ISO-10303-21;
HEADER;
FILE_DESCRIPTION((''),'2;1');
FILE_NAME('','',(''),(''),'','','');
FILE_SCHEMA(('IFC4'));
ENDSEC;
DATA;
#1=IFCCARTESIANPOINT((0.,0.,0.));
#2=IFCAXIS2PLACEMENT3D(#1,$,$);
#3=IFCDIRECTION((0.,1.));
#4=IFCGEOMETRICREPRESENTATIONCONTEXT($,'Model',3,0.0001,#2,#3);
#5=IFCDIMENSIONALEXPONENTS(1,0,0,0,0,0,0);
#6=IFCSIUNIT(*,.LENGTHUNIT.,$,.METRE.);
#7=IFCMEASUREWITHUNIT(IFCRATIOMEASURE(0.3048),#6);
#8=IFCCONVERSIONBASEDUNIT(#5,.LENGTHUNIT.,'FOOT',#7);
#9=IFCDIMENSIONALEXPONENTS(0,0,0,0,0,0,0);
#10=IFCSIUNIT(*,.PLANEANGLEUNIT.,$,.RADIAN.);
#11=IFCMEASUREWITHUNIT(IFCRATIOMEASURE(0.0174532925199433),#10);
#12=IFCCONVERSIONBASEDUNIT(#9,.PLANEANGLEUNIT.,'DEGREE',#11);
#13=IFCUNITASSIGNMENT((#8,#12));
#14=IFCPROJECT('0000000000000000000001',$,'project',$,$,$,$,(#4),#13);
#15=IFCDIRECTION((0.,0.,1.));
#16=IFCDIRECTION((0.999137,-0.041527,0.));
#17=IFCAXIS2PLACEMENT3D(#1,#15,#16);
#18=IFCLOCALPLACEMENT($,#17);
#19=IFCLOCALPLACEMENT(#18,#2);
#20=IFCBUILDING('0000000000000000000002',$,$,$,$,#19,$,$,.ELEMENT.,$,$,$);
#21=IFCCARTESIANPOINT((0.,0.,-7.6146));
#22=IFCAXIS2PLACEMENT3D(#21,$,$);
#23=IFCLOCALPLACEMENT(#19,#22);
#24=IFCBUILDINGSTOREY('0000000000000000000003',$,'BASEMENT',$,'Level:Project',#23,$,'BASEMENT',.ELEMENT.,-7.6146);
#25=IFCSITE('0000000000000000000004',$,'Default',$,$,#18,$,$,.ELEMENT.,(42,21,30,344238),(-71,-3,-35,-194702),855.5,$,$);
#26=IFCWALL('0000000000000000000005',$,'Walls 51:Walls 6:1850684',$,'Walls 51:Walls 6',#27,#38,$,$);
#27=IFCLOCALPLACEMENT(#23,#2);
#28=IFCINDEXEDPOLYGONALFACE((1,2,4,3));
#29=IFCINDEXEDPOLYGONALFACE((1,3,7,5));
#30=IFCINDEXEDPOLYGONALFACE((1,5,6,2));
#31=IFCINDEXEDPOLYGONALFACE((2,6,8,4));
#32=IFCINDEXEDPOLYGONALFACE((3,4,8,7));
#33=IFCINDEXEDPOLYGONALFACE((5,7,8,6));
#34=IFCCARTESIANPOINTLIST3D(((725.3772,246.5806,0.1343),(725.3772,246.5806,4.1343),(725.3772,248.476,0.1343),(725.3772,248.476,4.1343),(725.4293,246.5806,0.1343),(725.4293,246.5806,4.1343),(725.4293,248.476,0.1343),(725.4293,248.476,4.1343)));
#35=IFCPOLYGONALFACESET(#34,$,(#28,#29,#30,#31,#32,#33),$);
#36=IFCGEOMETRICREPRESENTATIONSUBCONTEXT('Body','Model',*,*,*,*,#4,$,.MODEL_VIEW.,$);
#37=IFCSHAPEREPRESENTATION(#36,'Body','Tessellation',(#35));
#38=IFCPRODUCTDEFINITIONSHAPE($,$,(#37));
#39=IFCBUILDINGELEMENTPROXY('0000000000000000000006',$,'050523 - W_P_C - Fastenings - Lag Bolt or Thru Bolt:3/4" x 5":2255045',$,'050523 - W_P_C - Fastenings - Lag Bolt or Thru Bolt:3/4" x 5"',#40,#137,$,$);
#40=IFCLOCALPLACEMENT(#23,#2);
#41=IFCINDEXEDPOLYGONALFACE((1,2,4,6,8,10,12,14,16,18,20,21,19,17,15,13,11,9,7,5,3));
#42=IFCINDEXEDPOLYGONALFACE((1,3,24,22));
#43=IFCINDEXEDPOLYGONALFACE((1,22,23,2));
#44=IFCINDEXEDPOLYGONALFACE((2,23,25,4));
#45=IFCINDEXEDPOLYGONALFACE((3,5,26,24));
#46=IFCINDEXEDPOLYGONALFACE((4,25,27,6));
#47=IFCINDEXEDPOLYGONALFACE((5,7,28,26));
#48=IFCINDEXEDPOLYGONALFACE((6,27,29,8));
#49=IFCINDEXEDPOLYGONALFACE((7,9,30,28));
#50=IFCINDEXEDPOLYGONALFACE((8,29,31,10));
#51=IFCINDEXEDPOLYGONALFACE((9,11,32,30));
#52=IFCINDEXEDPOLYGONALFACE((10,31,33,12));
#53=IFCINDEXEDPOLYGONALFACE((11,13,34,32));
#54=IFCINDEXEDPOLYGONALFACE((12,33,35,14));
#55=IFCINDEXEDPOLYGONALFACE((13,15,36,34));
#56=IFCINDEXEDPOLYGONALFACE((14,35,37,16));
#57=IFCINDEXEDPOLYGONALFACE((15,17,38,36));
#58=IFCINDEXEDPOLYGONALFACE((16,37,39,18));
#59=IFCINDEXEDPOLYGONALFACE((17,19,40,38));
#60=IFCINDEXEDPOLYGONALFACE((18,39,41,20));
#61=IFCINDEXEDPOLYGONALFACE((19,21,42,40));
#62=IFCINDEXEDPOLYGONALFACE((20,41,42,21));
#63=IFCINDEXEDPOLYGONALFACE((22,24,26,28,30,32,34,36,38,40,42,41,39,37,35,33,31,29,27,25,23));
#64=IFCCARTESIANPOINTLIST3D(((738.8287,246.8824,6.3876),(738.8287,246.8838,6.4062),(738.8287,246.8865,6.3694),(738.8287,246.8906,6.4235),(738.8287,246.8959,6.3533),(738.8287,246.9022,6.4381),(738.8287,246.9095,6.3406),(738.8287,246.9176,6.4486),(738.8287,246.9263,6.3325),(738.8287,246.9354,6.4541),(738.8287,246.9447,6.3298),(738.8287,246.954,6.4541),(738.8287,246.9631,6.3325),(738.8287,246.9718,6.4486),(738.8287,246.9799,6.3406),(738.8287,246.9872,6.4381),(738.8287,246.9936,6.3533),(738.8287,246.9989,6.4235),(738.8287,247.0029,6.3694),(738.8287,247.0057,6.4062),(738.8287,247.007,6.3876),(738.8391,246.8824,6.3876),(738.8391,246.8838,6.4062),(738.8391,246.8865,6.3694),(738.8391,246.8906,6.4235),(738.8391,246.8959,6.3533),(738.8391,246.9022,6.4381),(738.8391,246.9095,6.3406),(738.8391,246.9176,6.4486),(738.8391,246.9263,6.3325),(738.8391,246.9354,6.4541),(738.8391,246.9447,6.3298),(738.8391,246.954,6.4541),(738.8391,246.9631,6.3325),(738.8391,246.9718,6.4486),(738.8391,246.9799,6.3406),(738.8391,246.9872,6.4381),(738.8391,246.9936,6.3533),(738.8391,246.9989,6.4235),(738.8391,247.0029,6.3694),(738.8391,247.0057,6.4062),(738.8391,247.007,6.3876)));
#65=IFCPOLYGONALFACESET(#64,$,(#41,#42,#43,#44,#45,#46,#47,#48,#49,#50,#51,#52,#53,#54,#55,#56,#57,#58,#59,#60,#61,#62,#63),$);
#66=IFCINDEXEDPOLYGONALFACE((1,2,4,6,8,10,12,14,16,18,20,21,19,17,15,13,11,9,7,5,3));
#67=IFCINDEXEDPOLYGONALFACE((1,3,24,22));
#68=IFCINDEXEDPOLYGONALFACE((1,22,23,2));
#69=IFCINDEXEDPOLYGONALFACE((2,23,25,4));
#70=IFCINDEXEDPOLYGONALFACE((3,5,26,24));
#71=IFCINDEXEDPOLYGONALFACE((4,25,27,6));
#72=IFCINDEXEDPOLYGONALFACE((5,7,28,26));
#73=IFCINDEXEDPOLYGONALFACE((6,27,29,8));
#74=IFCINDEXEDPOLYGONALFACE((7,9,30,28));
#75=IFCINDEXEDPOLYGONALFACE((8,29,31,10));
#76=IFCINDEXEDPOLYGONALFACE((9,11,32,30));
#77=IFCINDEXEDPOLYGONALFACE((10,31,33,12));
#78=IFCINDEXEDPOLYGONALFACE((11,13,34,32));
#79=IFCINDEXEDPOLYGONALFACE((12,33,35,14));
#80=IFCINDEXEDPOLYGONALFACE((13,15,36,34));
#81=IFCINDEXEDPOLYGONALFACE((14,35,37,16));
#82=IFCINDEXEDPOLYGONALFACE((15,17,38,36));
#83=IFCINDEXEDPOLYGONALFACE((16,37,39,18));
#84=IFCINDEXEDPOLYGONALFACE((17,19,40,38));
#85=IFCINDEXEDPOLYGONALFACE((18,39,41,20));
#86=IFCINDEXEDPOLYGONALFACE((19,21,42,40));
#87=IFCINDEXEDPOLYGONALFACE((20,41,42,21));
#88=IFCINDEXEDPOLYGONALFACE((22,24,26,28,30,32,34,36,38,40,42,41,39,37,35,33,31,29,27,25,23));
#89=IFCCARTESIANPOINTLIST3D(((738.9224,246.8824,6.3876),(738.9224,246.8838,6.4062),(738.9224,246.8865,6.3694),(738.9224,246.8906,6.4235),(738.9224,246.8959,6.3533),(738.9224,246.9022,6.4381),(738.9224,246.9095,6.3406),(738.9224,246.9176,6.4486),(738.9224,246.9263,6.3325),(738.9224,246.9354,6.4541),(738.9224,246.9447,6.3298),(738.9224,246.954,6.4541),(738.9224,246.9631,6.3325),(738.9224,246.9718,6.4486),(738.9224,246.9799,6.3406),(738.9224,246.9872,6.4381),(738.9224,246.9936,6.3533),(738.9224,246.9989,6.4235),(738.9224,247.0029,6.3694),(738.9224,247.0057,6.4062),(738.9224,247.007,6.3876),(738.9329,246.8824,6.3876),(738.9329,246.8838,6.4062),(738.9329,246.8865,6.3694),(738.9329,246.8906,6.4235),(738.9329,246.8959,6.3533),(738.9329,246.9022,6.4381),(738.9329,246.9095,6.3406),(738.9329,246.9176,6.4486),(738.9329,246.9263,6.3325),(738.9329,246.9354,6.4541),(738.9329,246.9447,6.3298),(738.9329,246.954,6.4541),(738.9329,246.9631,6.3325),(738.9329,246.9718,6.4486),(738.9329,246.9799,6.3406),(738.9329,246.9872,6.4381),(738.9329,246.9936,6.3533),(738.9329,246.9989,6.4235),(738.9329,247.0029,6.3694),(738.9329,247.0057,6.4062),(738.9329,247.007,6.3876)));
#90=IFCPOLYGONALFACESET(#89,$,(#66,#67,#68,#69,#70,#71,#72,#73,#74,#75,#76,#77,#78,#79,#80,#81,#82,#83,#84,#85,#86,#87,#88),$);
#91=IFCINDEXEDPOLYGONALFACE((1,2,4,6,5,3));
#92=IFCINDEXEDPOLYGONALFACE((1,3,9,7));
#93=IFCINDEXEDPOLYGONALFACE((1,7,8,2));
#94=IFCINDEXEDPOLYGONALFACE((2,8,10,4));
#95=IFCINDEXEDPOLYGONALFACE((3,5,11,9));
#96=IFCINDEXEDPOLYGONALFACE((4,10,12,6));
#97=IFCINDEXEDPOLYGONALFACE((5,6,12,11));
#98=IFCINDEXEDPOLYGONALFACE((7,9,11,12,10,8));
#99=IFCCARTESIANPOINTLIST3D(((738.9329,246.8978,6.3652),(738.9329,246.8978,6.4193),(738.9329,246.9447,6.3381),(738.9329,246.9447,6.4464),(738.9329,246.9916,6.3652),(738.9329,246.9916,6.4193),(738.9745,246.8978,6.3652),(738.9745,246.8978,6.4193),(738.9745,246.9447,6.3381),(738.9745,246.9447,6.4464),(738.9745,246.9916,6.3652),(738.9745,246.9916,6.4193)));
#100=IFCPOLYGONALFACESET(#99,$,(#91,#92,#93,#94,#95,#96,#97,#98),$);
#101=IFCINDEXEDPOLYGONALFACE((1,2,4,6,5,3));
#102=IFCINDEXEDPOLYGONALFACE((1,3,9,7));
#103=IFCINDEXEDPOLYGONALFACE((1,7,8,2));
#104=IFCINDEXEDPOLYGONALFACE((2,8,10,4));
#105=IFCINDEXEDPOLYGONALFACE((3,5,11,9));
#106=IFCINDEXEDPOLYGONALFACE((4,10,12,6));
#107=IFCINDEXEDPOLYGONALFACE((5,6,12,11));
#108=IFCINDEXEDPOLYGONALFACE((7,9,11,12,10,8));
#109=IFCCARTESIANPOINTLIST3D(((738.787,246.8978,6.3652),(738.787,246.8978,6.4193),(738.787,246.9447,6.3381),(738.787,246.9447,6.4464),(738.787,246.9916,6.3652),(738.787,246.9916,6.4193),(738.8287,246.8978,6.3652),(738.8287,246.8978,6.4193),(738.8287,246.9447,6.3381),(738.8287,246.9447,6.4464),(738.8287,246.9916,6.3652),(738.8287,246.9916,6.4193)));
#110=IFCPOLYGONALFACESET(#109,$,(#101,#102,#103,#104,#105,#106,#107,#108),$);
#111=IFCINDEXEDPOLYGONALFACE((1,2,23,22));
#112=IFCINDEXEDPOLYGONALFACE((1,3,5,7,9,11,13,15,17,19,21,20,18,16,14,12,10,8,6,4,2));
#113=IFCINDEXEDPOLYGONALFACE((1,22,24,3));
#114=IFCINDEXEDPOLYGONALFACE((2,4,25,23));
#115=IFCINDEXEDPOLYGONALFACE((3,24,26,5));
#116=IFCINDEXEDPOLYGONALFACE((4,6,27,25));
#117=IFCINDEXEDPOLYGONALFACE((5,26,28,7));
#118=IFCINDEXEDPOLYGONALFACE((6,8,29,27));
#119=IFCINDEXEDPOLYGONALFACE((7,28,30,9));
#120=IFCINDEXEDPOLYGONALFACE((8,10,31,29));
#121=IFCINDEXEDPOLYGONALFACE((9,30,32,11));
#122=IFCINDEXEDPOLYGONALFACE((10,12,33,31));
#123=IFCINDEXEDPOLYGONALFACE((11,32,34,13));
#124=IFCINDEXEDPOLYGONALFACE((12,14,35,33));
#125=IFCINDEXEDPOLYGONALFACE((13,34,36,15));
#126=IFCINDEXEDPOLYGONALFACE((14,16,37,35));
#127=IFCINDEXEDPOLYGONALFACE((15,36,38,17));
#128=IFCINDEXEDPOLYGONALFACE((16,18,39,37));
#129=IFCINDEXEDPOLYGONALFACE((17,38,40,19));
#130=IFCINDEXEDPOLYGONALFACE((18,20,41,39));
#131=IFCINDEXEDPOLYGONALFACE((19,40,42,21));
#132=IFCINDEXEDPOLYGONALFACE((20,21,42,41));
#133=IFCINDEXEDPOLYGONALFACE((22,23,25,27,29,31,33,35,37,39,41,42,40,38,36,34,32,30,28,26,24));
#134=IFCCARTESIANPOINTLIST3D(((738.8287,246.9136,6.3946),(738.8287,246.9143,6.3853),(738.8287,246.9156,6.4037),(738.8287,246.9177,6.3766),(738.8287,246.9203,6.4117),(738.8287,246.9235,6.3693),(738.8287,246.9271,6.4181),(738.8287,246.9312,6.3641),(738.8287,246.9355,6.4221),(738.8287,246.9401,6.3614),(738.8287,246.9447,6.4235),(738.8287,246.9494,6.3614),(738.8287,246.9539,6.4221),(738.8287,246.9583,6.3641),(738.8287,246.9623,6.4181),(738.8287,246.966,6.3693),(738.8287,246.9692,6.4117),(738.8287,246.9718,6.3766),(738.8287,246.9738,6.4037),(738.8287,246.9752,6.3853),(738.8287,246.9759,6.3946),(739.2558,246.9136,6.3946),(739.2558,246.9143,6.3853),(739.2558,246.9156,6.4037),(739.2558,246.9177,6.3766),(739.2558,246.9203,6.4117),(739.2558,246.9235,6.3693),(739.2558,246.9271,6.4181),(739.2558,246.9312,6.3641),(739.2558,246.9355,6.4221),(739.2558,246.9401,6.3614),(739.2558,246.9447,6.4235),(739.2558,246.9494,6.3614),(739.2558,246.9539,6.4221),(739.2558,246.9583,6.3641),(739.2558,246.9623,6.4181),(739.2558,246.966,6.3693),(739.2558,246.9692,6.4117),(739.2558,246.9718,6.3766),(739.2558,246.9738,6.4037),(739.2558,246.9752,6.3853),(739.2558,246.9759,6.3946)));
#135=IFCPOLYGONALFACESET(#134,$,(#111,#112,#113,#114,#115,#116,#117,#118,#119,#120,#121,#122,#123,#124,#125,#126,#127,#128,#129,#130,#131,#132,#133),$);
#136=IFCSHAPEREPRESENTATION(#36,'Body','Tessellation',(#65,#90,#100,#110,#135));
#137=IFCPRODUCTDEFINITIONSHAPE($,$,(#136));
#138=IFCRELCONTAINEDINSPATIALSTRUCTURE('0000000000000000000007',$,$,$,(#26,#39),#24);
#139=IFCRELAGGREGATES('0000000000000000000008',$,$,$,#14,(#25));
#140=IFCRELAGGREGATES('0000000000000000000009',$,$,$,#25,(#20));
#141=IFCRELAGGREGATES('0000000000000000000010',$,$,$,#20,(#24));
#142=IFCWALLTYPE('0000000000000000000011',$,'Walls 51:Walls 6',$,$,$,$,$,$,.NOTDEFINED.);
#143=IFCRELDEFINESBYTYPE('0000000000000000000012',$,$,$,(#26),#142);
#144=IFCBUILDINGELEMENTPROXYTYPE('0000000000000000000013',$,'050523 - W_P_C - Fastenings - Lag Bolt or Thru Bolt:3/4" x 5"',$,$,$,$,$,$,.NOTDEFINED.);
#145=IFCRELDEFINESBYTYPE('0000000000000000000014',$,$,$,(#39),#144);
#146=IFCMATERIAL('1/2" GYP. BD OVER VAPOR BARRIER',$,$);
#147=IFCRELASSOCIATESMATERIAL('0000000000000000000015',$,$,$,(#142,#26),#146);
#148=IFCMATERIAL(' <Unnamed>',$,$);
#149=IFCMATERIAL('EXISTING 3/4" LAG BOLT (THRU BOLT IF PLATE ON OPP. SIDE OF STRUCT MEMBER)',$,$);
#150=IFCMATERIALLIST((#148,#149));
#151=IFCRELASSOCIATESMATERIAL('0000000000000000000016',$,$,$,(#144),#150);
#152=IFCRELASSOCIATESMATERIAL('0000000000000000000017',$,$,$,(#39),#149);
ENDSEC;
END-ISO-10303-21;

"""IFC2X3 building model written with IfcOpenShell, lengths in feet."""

from ifc_helpers import new_model, entity, si_unit, converted_unit, direction, frame, frame_2d, origin, place, context, subcontext, project, spatial, polyline, rectangle, circle, outline, extrude, source, transform, mapped, material, material_list, type_object, type_shapes, element, save


model = new_model("IFC2X3")

# Units and contexts
model_context = context("Model", 3, precision=0.0001, world=origin(), true_north=direction((0.0, 1.0)))
body_context = subcontext(model_context, "Body", "Model", "MODEL_VIEW")
ifc_project = project(units=[converted_unit("LENGTHUNIT", "FOOT", entity("IfcRatioMeasure", 0.3048), si_unit("LENGTHUNIT", "METRE"), dimensions=[1, 0, 0, 0, 0, 0, 0]), converted_unit("PLANEANGLEUNIT", "DEGREE", entity("IfcRatioMeasure", 0.0174532925199433), si_unit("PLANEANGLEUNIT", "RADIAN"), dimensions=[0, 0, 0, 0, 0, 0, 0])], contexts=[model_context])

# Site, building, storey
site_placement = place(None, frame((0.0, 0.0, 0.0), z_axis=(0.0, 0.0, 1.0), x_axis=(0.999137, -0.041527, 0.0)))
site = spatial("IfcSite", under=ifc_project, at=site_placement, Name="Default", CompositionType="ELEMENT", RefLatitude=(42, 21, 30, 344238), RefLongitude=(-71, -3, -35, -194702), RefElevation=855.5)
building_placement = place(site_placement, origin())
building = spatial("IfcBuilding", under=site, at=building_placement, CompositionType="ELEMENT")
storey_placement = place(building_placement, frame((0.0, 0.0, -7.6146)))
storey = spatial("IfcBuildingStorey", under=building, at=storey_placement, Name="BASEMENT", ObjectType="Level:Project", LongName="BASEMENT", CompositionType="ELEMENT", Elevation=-7.6146)

# Wall
ifc_material_1 = material(Name="1/2\" GYP. BD OVER VAPOR BARRIER")
wall_type = type_object("IfcWallType", Name="Walls 51:Walls 6", PredefinedType="NOTDEFINED", material=ifc_material_1)
wall_placement = place(storey_placement, frame((725.3772, 246.5806, 0.1343), z_axis=(0.0, 0.0, 1.0), x_axis=(0.0, 1.0, 0.0)))
element("IfcWall", 1, at=wall_placement, inside=storey, type_object=wall_type, material=ifc_material_1, Name="Walls 51:Walls 6:1850684", ObjectType="Walls 51:Walls 6", context=body_context, shape_type="SweptSolid", body=[
    extrude(rectangle(XDim=1.8954, YDim=0.0521, at=frame_2d((0.0, 0.0), x_axis=(1.0, 0.0))), frame((0.9477, -0.026, 0.0), z_axis=(0.0, 0.0, 1.0), x_axis=(-1.0, 0.0, 0.0)), (0.0, 0.0, 1.0), 4.0),
])

# Building element proxy
ifc_material_2 = material(Name="EXISTING 3/4\" LAG BOLT (THRU BOLT IF PLATE ON OPP. SIDE OF STRUCT MEMBER)")
ifc_material_3 = material(Name=" <Unnamed>")
ifc_material_list_1 = material_list([ifc_material_3, ifc_material_2])
building_element_proxy_type_1 = type_object("IfcBuildingElementProxyType", Name="050523 - W_P_C - Fastenings - Lag Bolt or Thru Bolt:3/4\" x 5\"", PredefinedType="NOTDEFINED", material=ifc_material_list_1)
shared_shape_1 = source(origin(), body_context, "Body", "SweptSolid", [
    extrude(circle(Radius=0.0625, at=frame_2d((0.0, 0.0), x_axis=(1.0, 0.0))), frame((0.0, 0.0, 0.0), z_axis=(0.0, 0.0, 1.0), x_axis=(0.0, -1.0, 0.0)), (0.0, 0.0, 1.0), 0.0104),
    extrude(circle(Radius=0.0625, at=frame_2d((0.0, 0.0), x_axis=(1.0, 0.0))), frame((0.0, 0.0, -0.0938), z_axis=(0.0, 0.0, 1.0), x_axis=(0.0, -1.0, 0.0)), (0.0, 0.0, 1.0), 0.0104),
    extrude(outline(polyline([(-0.0271, -0.0469), (0.0271, -0.0469), (0.0541, 0.0), (0.0271, 0.0469), (-0.0271, 0.0469), (-0.0541, 0.0), (-0.0271, -0.0469)])), frame((0.0, 0.0, -0.1354), z_axis=(0.0, 0.0, 1.0), x_axis=(0.866025, -0.5, 0.0)), (0.0, 0.0, 1.0), 0.0417),
    extrude(outline(polyline([(-0.0271, -0.0469), (0.0271, -0.0469), (0.0541, 0.0), (0.0271, 0.0469), (-0.0271, 0.0469), (-0.0541, 0.0), (-0.0271, -0.0469)])), frame((0.0, 0.0, 0.0104), z_axis=(0.0, 0.0, 1.0), x_axis=(0.0, -1.0, 0.0)), (0.0, 0.0, 1.0), 0.0417),
    extrude(circle(Radius=0.0312, at=frame_2d((0.0, 0.0), x_axis=(1.0, 0.0))), frame((0.0, 0.0, -0.4167), z_axis=(0.0, 0.0, 1.0), x_axis=(0.0, 1.0, 0.0)), (0.0, 0.0, 1.0), 0.4271),
])
type_shapes(building_element_proxy_type_1, [shared_shape_1])
for number, where, z_axis, x_axis, name in (
    (2, (738.8391, 246.9447, 6.3923), (-1.0, 0.0, 0.0), (0.0, -1.0, 0.0), "050523 - W_P_C - Fastenings - Lag Bolt or Thru Bolt:3/4\" x 5\":2255045"),
):
    element("IfcBuildingElementProxy", number, at=place(storey_placement, frame(where, z_axis=z_axis, x_axis=x_axis)), inside=storey, type_object=building_element_proxy_type_1, material=ifc_material_2, Name=name, ObjectType="050523 - W_P_C - Fastenings - Lag Bolt or Thru Bolt:3/4\" x 5\"", context=body_context, shape_type="MappedRepresentation", body=[
        mapped(shared_shape_1, transform((0.0, 0.0, 0.0), scale=1.0)),
    ])

save(model, "model.ifc")
